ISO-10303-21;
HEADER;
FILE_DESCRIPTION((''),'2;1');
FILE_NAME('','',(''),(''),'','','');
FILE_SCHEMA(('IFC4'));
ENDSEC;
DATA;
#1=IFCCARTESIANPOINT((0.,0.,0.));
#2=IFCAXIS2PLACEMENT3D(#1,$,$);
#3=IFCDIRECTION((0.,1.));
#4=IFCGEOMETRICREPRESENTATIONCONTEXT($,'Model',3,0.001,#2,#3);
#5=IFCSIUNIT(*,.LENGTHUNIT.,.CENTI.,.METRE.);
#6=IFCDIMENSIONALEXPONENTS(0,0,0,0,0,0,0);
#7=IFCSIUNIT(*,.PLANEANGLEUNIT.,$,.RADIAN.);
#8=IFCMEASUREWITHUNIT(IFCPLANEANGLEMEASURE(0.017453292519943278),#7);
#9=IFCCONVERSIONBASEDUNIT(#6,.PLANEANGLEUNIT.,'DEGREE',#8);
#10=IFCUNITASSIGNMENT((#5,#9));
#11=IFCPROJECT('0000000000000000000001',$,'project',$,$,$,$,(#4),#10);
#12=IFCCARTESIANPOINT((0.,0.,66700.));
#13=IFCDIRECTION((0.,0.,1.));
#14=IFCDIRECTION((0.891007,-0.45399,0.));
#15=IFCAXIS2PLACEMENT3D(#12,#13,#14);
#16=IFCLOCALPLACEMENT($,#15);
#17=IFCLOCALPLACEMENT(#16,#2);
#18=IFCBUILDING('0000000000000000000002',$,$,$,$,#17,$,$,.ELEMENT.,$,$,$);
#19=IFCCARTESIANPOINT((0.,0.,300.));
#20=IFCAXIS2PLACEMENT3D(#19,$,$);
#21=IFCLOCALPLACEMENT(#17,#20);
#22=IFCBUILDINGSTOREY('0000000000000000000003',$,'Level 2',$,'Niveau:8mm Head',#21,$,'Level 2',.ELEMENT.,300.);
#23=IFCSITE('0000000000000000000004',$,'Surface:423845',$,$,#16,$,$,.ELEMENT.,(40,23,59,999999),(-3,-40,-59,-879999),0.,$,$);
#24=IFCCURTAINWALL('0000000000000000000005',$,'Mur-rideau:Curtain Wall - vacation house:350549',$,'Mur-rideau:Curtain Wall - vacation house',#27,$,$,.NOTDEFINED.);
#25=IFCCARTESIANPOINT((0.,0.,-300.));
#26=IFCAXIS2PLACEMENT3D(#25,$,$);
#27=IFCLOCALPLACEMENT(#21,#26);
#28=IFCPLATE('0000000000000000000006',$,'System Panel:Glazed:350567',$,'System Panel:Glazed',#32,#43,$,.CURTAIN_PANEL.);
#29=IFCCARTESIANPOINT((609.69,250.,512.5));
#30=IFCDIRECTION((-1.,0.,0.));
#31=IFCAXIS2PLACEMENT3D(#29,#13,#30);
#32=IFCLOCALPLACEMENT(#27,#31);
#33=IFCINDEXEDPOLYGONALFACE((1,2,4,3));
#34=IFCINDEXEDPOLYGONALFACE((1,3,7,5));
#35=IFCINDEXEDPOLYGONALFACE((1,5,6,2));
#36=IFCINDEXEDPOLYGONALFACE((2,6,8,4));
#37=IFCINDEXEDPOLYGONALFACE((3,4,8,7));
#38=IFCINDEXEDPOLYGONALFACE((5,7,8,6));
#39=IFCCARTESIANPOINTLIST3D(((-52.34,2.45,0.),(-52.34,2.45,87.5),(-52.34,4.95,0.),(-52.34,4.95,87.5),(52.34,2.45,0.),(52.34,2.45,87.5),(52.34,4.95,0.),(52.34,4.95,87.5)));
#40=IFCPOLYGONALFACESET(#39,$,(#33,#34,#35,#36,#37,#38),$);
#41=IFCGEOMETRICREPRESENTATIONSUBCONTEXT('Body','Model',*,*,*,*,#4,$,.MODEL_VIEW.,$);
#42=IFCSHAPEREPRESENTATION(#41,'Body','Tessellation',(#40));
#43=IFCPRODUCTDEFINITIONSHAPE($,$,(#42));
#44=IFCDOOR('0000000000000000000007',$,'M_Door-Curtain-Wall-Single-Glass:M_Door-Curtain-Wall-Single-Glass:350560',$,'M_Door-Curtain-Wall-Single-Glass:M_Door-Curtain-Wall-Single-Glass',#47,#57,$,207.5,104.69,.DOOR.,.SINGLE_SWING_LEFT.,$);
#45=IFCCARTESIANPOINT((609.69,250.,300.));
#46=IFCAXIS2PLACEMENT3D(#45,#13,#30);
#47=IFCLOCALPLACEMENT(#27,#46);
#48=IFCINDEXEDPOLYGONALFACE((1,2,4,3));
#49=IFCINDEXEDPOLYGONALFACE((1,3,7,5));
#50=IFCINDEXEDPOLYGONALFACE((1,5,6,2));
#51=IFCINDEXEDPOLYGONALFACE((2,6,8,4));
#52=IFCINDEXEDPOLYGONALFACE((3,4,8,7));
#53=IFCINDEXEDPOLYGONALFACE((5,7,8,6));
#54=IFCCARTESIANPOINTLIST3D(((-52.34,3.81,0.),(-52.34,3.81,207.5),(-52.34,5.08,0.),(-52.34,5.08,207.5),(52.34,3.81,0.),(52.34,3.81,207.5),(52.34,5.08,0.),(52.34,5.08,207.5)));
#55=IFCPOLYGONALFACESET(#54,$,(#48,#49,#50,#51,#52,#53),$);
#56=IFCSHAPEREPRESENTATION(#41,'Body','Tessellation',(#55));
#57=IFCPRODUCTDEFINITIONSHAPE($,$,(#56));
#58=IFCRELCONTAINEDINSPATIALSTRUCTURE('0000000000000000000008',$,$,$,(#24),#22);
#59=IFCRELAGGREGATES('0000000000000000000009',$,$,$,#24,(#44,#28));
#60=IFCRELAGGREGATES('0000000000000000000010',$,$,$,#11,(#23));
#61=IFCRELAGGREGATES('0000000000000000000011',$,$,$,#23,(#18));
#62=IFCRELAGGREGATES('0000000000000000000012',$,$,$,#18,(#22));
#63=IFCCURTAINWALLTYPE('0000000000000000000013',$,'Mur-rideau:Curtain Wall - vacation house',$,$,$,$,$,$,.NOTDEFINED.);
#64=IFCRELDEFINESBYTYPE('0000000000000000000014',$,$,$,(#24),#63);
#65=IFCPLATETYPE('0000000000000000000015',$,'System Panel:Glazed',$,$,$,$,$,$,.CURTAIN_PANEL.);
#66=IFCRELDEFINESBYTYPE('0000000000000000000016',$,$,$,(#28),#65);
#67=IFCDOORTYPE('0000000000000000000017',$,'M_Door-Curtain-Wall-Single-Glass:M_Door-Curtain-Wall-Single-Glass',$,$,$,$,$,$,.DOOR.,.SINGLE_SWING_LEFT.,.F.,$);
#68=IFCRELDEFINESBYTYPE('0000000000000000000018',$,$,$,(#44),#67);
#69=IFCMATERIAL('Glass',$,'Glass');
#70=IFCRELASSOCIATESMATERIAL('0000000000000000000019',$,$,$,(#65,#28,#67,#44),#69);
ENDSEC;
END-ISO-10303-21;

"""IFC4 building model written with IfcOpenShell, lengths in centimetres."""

from ifc_helpers import new_model, entity, si_unit, converted_unit, direction, frame, frame_2d, origin, origin_2d_with_axis, place, context, subcontext, project, spatial, rectangle, extrude, source, transform, mapped, material, type_object, type_shapes, element, aggregate, save


model = new_model("IFC4")

# Units and contexts
model_context = context("Model", 3, precision=0.001, world=origin(), true_north=direction((0.0, 1.0)))
body_context = subcontext(model_context, "Body", "Model", "MODEL_VIEW")
ifc_project = project(units=[si_unit("LENGTHUNIT", "METRE", prefix="CENTI"), converted_unit("PLANEANGLEUNIT", "DEGREE", entity("IfcPlaneAngleMeasure", 0.017453292519943278), si_unit("PLANEANGLEUNIT", "RADIAN"), dimensions=[0, 0, 0, 0, 0, 0, 0])], contexts=[model_context])

# Site, building, storey
site_placement = place(None, frame((0.0, 0.0, 66700.0), z_axis=(0.0, 0.0, 1.0), x_axis=(0.891007, -0.45399, 0.0)))
site = spatial("IfcSite", under=ifc_project, at=site_placement, Name="Surface:423845", CompositionType="ELEMENT", RefLatitude=(40, 23, 59, 999999), RefLongitude=(-3, -40, -59, -879999), RefElevation=0.0)
building_placement = place(site_placement, origin())
building = spatial("IfcBuilding", under=site, at=building_placement, CompositionType="ELEMENT")
storey_placement = place(building_placement, frame((0.0, 0.0, 300.0)))
storey = spatial("IfcBuildingStorey", under=building, at=storey_placement, Name="Level 2", ObjectType="Niveau:8mm Head", LongName="Level 2", CompositionType="ELEMENT", Elevation=300.0)

# Curtain wall, plate
curtain_wall_type = type_object("IfcCurtainWallType", Name="Mur-rideau:Curtain Wall - vacation house", PredefinedType="NOTDEFINED")
curtain_wall_placement = place(storey_placement, frame((0.0, 0.0, -300.0)))
curtain_wall = element("IfcCurtainWall", 1, at=curtain_wall_placement, inside=storey, type_object=curtain_wall_type, Name="Mur-rideau:Curtain Wall - vacation house:350549", ObjectType="Mur-rideau:Curtain Wall - vacation house", PredefinedType="NOTDEFINED")
ifc_material_1 = material(Name="Glass", Category="Glass")
plate_type_1 = type_object("IfcPlateType", Name="System Panel:Glazed", PredefinedType="CURTAIN_PANEL", material=ifc_material_1)
shared_shape_1 = source(origin(), body_context, "Body", "SweptSolid", [
    extrude(rectangle(XDim=2.5, YDim=104.69, at=origin_2d_with_axis()), frame((0.0, 3.7, 0.0), z_axis=(0.0, 0.0, 1.0), x_axis=(0.0, 1.0, 0.0)), (0.0, 0.0, 1.0), 87.5),
])
type_shapes(plate_type_1, [shared_shape_1])
plate_1_placement = place(curtain_wall_placement, frame((609.69, 250.0, 512.5), z_axis=(0.0, 0.0, 1.0), x_axis=(-1.0, 0.0, 0.0)))
plate_1 = element("IfcPlate", 2, at=plate_1_placement, type_object=plate_type_1, material=ifc_material_1, Name="System Panel:Glazed:350567", ObjectType="System Panel:Glazed", PredefinedType="CURTAIN_PANEL", context=body_context, shape_type="MappedRepresentation", body=[
    mapped(shared_shape_1, transform((0.0, 0.0, 0.0), scale=1.0)),
])

# Door
door_type_1 = type_object("IfcDoorType", Name="M_Door-Curtain-Wall-Single-Glass:M_Door-Curtain-Wall-Single-Glass", OperationType="SINGLE_SWING_LEFT", ParameterTakesPrecedence=False, PredefinedType="DOOR", material=ifc_material_1)
shared_shape_2 = source(origin(), body_context, "Body", "SweptSolid", [
    extrude(rectangle(XDim=1.27, YDim=104.69, at=frame_2d((0.0, 0.0), x_axis=(1.0, 0.0))), frame((0.0, 4.45, 0.0), z_axis=(0.0, 0.0, 1.0), x_axis=(0.0, -1.0, 0.0)), (0.0, 0.0, 1.0), 207.5),
])
type_shapes(door_type_1, [shared_shape_2])
door_1_placement = place(curtain_wall_placement, frame((609.69, 250.0, 300.0), z_axis=(0.0, 0.0, 1.0), x_axis=(-1.0, 0.0, 0.0)))
door_1 = element("IfcDoor", 3, at=door_1_placement, type_object=door_type_1, material=ifc_material_1, Name="M_Door-Curtain-Wall-Single-Glass:M_Door-Curtain-Wall-Single-Glass:350560", ObjectType="M_Door-Curtain-Wall-Single-Glass:M_Door-Curtain-Wall-Single-Glass", OperationType="SINGLE_SWING_LEFT", OverallHeight=207.5, OverallWidth=104.69, PredefinedType="DOOR", context=body_context, shape_type="MappedRepresentation", body=[
    mapped(shared_shape_2, transform((0.0, 0.0, 0.0), scale=1.0)),
])
aggregate(curtain_wall, [door_1, plate_1])

save(model, "model.ifc")
